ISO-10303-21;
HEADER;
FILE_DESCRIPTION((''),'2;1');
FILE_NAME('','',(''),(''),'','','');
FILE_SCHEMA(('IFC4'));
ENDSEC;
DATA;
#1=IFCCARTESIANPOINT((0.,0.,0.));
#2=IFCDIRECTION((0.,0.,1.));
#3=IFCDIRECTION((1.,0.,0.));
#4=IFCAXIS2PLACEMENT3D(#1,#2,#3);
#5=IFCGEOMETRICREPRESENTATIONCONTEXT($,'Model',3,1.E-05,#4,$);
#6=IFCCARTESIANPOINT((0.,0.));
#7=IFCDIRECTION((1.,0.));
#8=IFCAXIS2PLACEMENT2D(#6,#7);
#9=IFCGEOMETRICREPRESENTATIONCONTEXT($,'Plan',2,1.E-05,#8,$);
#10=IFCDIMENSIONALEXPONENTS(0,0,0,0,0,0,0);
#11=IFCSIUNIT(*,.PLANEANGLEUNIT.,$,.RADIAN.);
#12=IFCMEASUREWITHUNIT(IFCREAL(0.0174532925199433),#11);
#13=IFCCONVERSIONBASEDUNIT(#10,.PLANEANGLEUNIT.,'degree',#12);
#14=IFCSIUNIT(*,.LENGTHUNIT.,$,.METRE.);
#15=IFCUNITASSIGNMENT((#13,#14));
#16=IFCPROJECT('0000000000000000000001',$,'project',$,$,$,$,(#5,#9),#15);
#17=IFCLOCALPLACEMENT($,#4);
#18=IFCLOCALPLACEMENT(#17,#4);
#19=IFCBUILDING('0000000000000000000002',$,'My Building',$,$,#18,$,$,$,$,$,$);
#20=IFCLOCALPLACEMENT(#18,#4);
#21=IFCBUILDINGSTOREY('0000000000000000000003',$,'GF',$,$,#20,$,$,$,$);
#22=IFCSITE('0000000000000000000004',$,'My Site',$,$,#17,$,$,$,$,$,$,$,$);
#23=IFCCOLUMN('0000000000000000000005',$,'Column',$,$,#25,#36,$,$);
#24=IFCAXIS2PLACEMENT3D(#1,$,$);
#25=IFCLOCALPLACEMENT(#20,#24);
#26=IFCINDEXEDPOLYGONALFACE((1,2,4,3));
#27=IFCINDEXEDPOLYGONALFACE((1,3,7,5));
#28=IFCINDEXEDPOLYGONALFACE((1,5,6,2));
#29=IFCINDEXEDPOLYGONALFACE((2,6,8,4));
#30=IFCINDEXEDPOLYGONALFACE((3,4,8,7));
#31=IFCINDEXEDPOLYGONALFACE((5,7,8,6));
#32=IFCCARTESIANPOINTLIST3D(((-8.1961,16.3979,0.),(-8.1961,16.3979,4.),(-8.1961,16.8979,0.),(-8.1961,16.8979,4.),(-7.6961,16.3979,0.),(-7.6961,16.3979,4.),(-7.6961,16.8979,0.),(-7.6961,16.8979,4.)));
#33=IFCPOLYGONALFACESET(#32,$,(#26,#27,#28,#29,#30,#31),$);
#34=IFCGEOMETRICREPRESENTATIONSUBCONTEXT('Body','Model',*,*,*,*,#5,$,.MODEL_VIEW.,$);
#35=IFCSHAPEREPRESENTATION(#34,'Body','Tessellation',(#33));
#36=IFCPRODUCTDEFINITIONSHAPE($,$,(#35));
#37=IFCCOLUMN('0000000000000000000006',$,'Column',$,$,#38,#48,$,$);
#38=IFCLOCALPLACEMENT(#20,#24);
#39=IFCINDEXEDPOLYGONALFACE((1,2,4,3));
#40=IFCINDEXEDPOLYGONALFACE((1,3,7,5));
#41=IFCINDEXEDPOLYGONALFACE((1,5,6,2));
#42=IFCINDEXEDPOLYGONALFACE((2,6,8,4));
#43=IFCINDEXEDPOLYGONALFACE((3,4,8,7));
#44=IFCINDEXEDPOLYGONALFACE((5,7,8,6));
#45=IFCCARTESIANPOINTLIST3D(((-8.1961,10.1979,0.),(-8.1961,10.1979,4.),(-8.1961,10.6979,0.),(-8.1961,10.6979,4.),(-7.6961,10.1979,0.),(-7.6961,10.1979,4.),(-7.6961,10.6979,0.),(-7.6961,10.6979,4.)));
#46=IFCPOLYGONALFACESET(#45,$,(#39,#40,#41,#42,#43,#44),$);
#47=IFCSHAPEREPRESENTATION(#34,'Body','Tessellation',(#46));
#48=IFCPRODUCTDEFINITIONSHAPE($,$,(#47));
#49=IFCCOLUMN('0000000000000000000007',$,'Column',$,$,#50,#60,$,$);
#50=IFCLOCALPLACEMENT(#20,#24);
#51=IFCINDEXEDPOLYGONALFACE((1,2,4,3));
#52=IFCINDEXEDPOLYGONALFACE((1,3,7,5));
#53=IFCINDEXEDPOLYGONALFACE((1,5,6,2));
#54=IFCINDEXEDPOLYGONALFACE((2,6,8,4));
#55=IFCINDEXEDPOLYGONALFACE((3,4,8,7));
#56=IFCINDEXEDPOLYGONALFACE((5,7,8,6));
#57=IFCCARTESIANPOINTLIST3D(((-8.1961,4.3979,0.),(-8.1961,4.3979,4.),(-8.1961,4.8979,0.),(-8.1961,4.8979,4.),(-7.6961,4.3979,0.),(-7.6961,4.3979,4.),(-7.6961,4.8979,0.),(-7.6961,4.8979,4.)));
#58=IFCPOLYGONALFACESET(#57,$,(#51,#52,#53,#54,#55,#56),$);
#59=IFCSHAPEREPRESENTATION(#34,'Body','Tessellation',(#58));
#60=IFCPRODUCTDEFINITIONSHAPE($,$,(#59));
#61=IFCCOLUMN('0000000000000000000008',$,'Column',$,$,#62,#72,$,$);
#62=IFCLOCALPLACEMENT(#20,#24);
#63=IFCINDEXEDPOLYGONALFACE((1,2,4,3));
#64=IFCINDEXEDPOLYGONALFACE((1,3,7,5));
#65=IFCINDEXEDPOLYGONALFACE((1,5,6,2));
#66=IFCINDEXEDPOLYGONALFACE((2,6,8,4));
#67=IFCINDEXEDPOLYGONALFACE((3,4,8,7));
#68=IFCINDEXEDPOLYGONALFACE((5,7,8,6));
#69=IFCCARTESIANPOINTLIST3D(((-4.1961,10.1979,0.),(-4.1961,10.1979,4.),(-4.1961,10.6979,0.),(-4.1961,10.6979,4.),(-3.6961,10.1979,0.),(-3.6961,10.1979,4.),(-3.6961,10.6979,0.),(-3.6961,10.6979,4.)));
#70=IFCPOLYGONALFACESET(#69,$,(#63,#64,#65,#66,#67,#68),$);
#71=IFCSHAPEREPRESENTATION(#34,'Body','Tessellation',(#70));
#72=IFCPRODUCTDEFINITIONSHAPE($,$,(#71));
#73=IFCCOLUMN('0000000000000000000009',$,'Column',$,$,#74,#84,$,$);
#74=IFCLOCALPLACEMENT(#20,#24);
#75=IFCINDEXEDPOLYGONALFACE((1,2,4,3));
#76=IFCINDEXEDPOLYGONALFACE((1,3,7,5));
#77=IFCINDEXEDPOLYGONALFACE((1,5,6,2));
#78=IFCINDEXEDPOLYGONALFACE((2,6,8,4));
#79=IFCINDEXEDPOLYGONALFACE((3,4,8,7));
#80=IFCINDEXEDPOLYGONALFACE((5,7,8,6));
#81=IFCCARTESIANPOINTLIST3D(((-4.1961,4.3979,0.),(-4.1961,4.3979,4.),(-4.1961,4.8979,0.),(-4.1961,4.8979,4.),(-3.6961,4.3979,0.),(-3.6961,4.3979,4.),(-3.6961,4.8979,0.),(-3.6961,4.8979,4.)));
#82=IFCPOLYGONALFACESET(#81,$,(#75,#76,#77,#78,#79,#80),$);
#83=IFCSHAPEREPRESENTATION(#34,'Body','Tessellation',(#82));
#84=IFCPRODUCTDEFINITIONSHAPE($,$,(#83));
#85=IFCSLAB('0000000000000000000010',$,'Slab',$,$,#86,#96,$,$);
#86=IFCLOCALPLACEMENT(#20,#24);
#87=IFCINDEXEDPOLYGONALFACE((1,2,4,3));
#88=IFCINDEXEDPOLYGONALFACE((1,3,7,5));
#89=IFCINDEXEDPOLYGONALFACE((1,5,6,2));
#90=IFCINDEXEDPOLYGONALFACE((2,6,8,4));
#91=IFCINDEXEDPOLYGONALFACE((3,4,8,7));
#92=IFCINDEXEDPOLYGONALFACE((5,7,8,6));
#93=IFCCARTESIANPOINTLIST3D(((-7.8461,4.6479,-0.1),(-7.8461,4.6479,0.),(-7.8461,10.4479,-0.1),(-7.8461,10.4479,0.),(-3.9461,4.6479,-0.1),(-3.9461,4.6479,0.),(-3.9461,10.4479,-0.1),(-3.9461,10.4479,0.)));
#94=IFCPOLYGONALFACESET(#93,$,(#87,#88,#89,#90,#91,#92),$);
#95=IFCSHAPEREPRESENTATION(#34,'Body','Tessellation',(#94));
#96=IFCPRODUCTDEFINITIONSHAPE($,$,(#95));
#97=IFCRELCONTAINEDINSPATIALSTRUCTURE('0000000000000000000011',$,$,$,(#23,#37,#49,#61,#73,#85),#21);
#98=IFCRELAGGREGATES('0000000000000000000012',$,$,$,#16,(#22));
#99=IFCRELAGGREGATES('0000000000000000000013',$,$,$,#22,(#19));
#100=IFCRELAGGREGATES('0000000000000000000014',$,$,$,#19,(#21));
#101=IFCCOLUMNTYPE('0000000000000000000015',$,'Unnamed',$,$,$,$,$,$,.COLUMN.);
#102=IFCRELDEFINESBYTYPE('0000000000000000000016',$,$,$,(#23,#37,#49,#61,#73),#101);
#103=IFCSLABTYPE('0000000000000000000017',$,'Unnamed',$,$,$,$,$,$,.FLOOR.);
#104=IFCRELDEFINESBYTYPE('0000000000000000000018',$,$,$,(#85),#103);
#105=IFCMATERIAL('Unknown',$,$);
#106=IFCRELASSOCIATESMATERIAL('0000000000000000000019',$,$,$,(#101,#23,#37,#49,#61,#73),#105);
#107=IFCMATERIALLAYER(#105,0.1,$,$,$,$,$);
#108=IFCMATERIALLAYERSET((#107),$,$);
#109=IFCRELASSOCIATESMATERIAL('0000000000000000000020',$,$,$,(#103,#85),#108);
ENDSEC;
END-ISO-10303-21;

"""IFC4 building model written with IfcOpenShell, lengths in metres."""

from ifc_helpers import new_model, entity, si_unit, converted_unit, frame, origin_with_axes, origin_2d_with_axis, place, context, subcontext, project, spatial, indexed_curve, rectangle, outline, extrude, material, layer, layer_set, layer_usage, material_profile, profile_set, profile_usage, type_object, element, save


model = new_model("IFC4")

# Units and contexts
model_context = context("Model", 3, precision=1e-05, world=origin_with_axes())
plan_context = context("Plan", 2, precision=1e-05, world=origin_2d_with_axis())
body_context_1 = subcontext(model_context, "Body", "Model", "MODEL_VIEW")
ifc_project = project(units=[converted_unit("PLANEANGLEUNIT", "degree", entity("IfcReal", 0.0174532925199433), si_unit("PLANEANGLEUNIT", "RADIAN"), dimensions=[0, 0, 0, 0, 0, 0, 0]), si_unit("LENGTHUNIT", "METRE")], contexts=[model_context, plan_context])

# Site, building, storey
site_placement = place(None, origin_with_axes())
site = spatial("IfcSite", under=ifc_project, at=site_placement, Name="My Site")
building_placement = place(site_placement, origin_with_axes())
building = spatial("IfcBuilding", under=site, at=building_placement, Name="My Building")
storey_placement = place(building_placement, origin_with_axes())
storey = spatial("IfcBuildingStorey", under=building, at=storey_placement, Name="GF")

# Columns
ifc_material = material(Name="Unknown")
ifc_material_profile = material_profile(ifc_material, rectangle(XDim=0.5, YDim=0.5))
ifc_profile_set = profile_set([ifc_material_profile])
ifc_profile_usage_1 = profile_usage(ifc_profile_set, cardinal=5)
column_type = type_object("IfcColumnType", Name="Unnamed", PredefinedType="COLUMN", material=ifc_profile_set)
column_1_placement = place(storey_placement, frame((-7.9461, 16.6479, 0.0), z_axis=(0.0, 0.0, 1.0), x_axis=(1.0, 0.0, 0.0)))
element("IfcColumn", 1, at=column_1_placement, inside=storey, type_object=column_type, material=ifc_profile_usage_1, Name="Column", context=body_context_1, shape_type="SweptSolid", body=[
    extrude(rectangle(XDim=0.5, YDim=0.5), origin_with_axes(), (0.0, 0.0, 1.0), 4.0),
])
ifc_profile_usage_2 = profile_usage(ifc_profile_set, cardinal=5)
column_2_placement = place(storey_placement, frame((-7.9461, 10.4479, 0.0), z_axis=(0.0, 0.0, 1.0), x_axis=(1.0, 0.0, 0.0)))
element("IfcColumn", 2, at=column_2_placement, inside=storey, type_object=column_type, material=ifc_profile_usage_2, Name="Column", context=body_context_1, shape_type="SweptSolid", body=[
    extrude(rectangle(XDim=0.5, YDim=0.5), origin_with_axes(), (0.0, 0.0, 1.0), 4.0),
])
ifc_profile_usage_3 = profile_usage(ifc_profile_set, cardinal=5)
column_3_placement = place(storey_placement, frame((-7.9461, 4.6479, 0.0), z_axis=(0.0, 0.0, 1.0), x_axis=(1.0, 0.0, 0.0)))
element("IfcColumn", 3, at=column_3_placement, inside=storey, type_object=column_type, material=ifc_profile_usage_3, Name="Column", context=body_context_1, shape_type="SweptSolid", body=[
    extrude(rectangle(XDim=0.5, YDim=0.5), origin_with_axes(), (0.0, 0.0, 1.0), 4.0),
])
ifc_profile_usage_4 = profile_usage(ifc_profile_set, cardinal=5)
column_4_placement = place(storey_placement, frame((-3.9461, 10.4479, 0.0), z_axis=(0.0, 0.0, 1.0), x_axis=(1.0, 0.0, 0.0)))
element("IfcColumn", 4, at=column_4_placement, inside=storey, type_object=column_type, material=ifc_profile_usage_4, Name="Column", context=body_context_1, shape_type="SweptSolid", body=[
    extrude(rectangle(XDim=0.5, YDim=0.5), origin_with_axes(), (0.0, 0.0, 1.0), 4.0),
])
ifc_profile_usage_5 = profile_usage(ifc_profile_set, cardinal=5)
column_5_placement = place(storey_placement, frame((-3.9461, 4.6479, 0.0), z_axis=(0.0, 0.0, 1.0), x_axis=(1.0, 0.0, 0.0)))
element("IfcColumn", 5, at=column_5_placement, inside=storey, type_object=column_type, material=ifc_profile_usage_5, Name="Column", context=body_context_1, shape_type="SweptSolid", body=[
    extrude(rectangle(XDim=0.5, YDim=0.5), origin_with_axes(), (0.0, 0.0, 1.0), 4.0),
])

# Slab
ifc_layer_1 = layer(ifc_material, 0.1)
ifc_layer_set_1 = layer_set([ifc_layer_1])
ifc_layer_usage_1 = layer_usage(ifc_layer_set_1, "AXIS3", "POSITIVE", -0.1)
slab_type = type_object("IfcSlabType", Name="Unnamed", PredefinedType="FLOOR", material=ifc_layer_set_1)
slab_placement = place(storey_placement, frame((-7.8461, 10.4479, 0.0), z_axis=(0.0, 0.0, 1.0), x_axis=(1.0, 0.0, 0.0)))
element("IfcSlab", 6, at=slab_placement, inside=storey, type_object=slab_type, material=ifc_layer_usage_1, Name="Slab", context=body_context_1, shape_type="SweptSolid", body=[
    extrude(outline(indexed_curve([(0.0, 0.0), (3.9, 0.0), (3.9, -5.8), (0.0, -5.8), (0.0, 0.0)])), frame((0.0, 0.0, -0.1), z_axis=(0.0, 0.0, 1.0), x_axis=(1.0, 0.0, 0.0)), (0.0, 0.0, 1.0), 0.1),
])

save(model, "model.ifc")
